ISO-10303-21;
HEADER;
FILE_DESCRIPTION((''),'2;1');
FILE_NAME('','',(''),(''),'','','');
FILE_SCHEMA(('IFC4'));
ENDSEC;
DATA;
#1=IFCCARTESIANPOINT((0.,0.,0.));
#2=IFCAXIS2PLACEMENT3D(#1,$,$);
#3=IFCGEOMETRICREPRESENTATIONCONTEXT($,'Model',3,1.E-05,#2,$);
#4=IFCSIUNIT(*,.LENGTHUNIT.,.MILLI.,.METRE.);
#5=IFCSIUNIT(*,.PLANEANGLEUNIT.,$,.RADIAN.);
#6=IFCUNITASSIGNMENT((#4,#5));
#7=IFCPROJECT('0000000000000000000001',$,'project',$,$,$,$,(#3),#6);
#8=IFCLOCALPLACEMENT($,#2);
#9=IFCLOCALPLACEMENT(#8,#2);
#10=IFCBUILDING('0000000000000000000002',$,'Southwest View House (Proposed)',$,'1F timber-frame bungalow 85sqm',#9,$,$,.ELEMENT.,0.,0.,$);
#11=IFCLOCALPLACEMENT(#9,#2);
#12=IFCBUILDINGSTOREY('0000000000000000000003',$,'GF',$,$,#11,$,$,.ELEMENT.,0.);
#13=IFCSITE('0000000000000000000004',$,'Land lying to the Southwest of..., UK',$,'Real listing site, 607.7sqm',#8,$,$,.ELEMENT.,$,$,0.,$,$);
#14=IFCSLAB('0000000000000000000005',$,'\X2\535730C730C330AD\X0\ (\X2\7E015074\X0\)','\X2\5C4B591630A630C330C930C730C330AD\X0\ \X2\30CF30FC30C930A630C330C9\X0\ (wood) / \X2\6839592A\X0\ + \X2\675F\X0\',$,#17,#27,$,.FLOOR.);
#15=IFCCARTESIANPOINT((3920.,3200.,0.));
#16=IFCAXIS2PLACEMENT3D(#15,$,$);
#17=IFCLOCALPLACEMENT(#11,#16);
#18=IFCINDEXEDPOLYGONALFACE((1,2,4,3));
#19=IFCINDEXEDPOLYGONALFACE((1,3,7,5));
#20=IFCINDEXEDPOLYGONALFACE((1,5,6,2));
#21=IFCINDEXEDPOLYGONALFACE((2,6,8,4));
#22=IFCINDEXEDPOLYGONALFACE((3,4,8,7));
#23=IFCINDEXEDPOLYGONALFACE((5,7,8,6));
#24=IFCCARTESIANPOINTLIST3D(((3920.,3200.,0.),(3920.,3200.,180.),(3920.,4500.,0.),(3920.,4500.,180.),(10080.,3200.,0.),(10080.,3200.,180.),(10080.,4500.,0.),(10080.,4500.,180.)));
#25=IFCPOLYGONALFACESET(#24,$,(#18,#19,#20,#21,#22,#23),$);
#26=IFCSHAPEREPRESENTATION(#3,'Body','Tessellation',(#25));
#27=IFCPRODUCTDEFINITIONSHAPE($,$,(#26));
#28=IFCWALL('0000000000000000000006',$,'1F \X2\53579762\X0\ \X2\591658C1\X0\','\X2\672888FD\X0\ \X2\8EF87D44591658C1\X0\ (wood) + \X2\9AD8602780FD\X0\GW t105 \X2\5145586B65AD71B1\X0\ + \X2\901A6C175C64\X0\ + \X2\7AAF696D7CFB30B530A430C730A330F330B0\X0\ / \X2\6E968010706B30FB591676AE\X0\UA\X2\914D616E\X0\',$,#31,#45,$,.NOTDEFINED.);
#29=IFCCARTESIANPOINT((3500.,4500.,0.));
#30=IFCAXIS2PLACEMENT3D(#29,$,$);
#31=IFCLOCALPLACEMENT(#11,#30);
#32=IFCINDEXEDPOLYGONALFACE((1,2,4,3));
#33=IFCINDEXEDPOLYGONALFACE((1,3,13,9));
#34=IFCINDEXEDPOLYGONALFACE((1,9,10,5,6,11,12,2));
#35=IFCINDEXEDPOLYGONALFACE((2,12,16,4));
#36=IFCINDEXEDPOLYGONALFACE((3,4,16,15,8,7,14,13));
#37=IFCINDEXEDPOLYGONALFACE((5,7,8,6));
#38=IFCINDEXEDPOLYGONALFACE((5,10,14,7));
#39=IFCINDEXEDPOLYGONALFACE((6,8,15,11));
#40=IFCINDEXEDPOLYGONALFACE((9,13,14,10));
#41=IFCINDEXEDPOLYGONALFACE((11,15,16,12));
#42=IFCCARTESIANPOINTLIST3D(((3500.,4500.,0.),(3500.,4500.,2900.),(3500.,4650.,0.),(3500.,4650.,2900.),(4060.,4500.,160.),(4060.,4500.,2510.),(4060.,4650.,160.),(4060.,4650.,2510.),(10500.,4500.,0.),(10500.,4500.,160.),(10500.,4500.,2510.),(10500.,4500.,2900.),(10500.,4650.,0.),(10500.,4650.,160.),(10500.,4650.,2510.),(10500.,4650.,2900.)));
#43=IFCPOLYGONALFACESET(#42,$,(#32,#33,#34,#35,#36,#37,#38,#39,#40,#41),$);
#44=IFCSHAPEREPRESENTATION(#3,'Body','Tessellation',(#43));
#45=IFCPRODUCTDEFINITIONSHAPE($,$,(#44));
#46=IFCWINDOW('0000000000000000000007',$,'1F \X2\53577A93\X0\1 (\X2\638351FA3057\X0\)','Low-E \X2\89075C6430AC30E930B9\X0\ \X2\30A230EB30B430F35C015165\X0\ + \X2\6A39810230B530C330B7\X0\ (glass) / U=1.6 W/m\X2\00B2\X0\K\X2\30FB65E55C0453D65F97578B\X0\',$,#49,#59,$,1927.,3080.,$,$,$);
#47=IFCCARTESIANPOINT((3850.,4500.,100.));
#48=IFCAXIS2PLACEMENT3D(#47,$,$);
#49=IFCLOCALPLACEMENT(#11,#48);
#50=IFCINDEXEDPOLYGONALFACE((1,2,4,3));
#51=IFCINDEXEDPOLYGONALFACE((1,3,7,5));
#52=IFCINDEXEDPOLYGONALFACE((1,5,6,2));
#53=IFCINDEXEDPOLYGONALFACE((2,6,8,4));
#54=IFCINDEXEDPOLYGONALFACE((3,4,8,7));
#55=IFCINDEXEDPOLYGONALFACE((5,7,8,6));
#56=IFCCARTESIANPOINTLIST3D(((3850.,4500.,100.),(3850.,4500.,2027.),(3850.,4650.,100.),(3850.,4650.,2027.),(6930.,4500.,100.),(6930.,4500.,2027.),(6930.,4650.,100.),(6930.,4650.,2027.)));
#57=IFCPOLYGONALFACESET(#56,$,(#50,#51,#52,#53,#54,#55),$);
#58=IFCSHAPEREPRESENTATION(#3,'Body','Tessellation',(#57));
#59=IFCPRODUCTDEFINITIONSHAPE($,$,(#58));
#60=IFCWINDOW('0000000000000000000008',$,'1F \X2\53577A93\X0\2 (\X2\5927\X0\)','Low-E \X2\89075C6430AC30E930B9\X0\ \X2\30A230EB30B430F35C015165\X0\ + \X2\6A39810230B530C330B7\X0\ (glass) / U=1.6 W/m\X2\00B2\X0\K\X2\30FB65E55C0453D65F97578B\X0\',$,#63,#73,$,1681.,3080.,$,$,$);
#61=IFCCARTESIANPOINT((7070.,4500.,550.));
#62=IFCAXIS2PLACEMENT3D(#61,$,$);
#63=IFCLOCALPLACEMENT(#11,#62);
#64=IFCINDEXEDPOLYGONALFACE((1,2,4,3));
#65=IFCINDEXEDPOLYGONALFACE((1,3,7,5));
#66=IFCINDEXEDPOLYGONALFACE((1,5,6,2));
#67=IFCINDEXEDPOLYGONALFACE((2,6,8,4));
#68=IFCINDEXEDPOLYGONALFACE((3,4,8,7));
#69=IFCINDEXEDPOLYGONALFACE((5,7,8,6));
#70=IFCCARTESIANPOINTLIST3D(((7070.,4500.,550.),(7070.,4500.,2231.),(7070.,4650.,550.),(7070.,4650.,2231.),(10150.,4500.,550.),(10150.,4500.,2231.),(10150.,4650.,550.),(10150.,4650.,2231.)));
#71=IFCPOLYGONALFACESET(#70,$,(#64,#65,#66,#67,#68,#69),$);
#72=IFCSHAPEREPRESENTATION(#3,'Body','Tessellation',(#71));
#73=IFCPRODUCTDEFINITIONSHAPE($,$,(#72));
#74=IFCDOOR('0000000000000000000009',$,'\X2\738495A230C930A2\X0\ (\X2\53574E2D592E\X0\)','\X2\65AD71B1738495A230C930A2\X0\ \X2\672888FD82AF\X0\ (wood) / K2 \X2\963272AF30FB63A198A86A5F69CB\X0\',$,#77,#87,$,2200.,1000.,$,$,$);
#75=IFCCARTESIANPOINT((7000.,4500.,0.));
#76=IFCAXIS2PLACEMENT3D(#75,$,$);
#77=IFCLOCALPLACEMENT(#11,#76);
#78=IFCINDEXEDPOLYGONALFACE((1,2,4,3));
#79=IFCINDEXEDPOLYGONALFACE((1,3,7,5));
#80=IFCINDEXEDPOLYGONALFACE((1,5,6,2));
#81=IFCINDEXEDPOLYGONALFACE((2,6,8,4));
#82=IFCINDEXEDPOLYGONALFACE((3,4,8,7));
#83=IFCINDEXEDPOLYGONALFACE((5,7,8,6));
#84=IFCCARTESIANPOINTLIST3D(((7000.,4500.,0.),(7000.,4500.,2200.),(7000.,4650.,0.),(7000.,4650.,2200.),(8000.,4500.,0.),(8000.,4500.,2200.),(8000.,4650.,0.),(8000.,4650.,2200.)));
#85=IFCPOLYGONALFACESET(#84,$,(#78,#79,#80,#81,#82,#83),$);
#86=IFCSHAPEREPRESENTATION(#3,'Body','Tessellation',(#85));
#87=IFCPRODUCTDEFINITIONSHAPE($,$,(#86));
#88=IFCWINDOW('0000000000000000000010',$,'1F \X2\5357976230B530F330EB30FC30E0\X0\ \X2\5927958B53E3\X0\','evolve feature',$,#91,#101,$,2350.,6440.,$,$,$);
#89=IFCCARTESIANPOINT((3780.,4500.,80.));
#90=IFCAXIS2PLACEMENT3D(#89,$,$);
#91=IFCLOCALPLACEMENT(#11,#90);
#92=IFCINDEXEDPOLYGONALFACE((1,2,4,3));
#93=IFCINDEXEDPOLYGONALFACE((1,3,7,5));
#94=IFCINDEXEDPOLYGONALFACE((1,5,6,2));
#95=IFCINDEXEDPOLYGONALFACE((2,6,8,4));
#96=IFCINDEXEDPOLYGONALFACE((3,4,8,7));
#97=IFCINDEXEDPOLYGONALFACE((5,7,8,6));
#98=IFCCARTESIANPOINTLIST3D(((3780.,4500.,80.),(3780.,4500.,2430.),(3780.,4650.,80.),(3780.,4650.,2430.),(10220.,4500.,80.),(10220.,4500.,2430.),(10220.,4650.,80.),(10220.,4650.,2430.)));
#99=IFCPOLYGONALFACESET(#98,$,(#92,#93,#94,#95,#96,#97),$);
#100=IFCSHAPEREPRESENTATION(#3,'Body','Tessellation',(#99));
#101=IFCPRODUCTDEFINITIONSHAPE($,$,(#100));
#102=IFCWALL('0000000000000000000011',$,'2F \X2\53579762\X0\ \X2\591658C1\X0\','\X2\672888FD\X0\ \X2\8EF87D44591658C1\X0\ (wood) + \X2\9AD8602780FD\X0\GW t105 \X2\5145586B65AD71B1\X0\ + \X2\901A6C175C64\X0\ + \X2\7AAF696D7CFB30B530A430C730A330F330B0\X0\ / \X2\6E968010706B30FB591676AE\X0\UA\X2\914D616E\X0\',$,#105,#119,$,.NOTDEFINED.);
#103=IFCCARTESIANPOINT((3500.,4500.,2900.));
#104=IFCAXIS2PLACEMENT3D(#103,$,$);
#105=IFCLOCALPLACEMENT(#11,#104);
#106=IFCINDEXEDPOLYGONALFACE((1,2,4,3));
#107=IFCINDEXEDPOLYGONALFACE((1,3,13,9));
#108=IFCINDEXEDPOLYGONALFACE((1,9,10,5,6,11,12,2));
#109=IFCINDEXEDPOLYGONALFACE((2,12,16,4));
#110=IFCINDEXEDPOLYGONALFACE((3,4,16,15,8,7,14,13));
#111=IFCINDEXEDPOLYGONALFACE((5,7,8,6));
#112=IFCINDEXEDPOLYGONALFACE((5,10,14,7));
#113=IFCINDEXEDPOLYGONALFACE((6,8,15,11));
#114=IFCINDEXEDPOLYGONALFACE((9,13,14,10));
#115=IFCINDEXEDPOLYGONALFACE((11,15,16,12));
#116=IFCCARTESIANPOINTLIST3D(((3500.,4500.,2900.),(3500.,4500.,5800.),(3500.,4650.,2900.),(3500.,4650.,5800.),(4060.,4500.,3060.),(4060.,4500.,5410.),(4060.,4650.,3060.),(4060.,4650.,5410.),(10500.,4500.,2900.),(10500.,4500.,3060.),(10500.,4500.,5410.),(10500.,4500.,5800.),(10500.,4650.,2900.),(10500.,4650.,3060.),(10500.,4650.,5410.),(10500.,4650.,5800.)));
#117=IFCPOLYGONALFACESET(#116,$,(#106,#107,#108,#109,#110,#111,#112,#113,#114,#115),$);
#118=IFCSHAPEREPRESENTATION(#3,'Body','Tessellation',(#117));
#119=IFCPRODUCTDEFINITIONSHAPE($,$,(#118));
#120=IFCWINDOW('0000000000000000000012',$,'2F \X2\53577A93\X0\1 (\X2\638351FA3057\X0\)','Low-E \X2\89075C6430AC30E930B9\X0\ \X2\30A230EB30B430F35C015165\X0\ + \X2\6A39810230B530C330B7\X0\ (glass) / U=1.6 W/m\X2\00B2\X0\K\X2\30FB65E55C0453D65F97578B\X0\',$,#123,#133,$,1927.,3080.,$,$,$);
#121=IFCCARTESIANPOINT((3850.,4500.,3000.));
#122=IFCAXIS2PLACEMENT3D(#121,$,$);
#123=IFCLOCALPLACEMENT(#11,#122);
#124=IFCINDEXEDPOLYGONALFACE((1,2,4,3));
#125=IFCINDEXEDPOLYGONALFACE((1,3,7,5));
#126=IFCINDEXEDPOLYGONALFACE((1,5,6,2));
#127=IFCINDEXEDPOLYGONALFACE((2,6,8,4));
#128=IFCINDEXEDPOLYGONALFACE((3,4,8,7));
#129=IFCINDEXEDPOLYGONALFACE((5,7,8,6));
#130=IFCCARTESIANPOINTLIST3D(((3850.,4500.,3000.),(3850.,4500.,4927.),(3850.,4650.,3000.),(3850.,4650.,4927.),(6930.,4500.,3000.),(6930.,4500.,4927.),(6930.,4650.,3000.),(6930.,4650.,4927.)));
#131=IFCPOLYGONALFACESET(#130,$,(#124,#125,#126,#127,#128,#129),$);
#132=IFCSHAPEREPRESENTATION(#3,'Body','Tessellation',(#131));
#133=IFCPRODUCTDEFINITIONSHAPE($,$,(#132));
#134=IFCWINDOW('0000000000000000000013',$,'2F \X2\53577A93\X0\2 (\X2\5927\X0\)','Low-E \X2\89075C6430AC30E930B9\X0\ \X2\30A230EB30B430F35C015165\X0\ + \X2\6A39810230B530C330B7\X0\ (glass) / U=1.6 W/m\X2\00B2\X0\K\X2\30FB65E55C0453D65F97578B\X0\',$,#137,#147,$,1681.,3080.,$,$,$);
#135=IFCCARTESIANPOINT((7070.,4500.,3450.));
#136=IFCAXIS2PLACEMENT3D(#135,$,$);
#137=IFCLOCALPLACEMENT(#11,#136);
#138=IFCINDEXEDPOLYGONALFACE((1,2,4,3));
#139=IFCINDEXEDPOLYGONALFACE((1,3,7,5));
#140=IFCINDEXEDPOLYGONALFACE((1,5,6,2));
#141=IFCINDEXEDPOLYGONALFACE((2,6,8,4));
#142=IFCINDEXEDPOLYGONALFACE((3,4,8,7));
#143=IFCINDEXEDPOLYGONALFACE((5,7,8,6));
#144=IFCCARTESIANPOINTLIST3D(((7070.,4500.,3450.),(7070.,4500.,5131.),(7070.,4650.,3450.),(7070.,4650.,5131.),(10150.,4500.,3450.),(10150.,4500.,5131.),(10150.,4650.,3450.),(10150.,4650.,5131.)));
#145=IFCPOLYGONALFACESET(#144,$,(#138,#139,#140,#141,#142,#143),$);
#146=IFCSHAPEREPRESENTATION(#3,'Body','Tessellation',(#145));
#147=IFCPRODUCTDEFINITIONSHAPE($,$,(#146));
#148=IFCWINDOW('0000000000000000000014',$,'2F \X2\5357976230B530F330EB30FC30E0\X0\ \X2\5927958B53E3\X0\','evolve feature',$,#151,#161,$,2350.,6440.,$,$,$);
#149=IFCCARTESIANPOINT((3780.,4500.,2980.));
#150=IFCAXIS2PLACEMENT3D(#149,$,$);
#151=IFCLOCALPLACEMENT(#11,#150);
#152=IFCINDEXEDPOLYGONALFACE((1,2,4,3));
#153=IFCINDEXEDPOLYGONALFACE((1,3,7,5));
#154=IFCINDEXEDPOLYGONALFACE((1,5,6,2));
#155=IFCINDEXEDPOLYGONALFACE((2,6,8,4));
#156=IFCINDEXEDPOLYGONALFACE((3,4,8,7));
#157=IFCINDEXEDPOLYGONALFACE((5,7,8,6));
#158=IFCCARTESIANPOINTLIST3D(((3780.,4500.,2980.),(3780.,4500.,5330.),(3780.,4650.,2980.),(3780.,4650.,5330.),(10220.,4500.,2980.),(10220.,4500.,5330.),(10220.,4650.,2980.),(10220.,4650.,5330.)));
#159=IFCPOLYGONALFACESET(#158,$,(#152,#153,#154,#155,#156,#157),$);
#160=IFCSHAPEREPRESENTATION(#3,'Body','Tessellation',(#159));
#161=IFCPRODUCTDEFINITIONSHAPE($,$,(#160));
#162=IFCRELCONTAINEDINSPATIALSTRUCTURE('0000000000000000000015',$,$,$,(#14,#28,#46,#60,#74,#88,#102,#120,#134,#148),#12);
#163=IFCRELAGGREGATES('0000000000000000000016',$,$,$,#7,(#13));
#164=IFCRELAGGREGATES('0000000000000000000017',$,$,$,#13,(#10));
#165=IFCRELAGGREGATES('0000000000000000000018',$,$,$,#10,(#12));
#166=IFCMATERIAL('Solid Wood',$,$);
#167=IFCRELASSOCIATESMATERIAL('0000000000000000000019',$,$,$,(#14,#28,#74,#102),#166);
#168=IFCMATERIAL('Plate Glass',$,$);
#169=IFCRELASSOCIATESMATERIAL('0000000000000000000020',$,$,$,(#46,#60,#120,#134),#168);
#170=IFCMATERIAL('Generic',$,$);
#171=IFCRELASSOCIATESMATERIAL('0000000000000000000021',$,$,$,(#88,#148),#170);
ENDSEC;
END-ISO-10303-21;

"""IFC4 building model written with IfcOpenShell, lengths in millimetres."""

from ifc_helpers import new_model, si_unit, frame, frame_2d, origin, place, context, project, spatial, rectangle, extrude, material, element, fill, save


model = new_model("IFC4")

# Units and contexts
model_context = context("Model", 3, precision=1e-05, world=origin())
ifc_project = project(units=[si_unit("LENGTHUNIT", "METRE", prefix="MILLI"), si_unit("PLANEANGLEUNIT", "RADIAN")], contexts=[model_context])

# Site, building, storey
site_placement = place(None, origin())
site = spatial("IfcSite", under=ifc_project, at=site_placement, Name="Land lying to the Southwest of..., UK", ObjectType="Real listing site, 607.7sqm", CompositionType="ELEMENT", RefElevation=0.0)
building_placement = place(site_placement, origin())
building = spatial("IfcBuilding", under=site, at=building_placement, Name="Southwest View House (Proposed)", ObjectType="1F timber-frame bungalow 85sqm", CompositionType="ELEMENT", ElevationOfRefHeight=0.0, ElevationOfTerrain=0.0)
storey_placement = place(building_placement, origin())
storey = spatial("IfcBuildingStorey", under=building, at=storey_placement, Name="GF", CompositionType="ELEMENT", Elevation=0.0)

# Slab
ifc_material_1 = material(Name="Solid Wood")
slab_1_placement = place(storey_placement, frame((3920.0, 3200.0, 0.0)))
element("IfcSlab", 1, at=slab_1_placement, inside=storey, material=ifc_material_1, Name="南デッキ (縁側)", Description="屋外ウッドデッキ ハードウッド (wood) / 根太 + 束", PredefinedType="FLOOR", context=model_context, shape_type="SweptSolid", body=[
    extrude(rectangle(XDim=6160.0, YDim=1300.0, at=frame_2d((3080.0, 650.0))), frame((3920.0, 3200.0, 0.0)), (0.0, 0.0, 1.0), 180.0),
])
ifc_material_2 = material(Name="Generic")

# Wall, openings, windows, door
wall_1_placement = place(storey_placement, frame((3500.0, 4500.0, 0.0)))
wall_1 = element("IfcWall", 2, at=wall_1_placement, inside=storey, material=ifc_material_1, Name="1F 南面 外壁", Description="木製 軸組外壁 (wood) + 高性能GW t105 充填断熱 + 通気層 + 窯業系サイディング / 準耐火・外皮UA配慮", PredefinedType="NOTDEFINED", context=model_context, shape_type="SweptSolid", body=[
    extrude(rectangle(XDim=7000.0, YDim=150.0, at=frame_2d((3500.0, 75.0))), frame((3500.0, 4500.0, 0.0)), (0.0, 0.0, 1.0), 2900.0),
])
opening_1_placement = place(storey_placement, frame((3850.0, 4500.0, 100.0)))
opening_1 = element("IfcOpeningElement", 3, at=opening_1_placement, cuts=wall_1, PredefinedType="NOTDEFINED", context=model_context, shape_type="SweptSolid", body=[
    extrude(rectangle(XDim=3080.0, YDim=150.0, at=frame_2d((1540.0, 75.0))), frame((3850.0, 4500.0, 100.0)), (0.0, 0.0, 1.0), 1927.0),
])
opening_2_placement = place(storey_placement, frame((7070.0, 4500.0, 550.0)))
opening_2 = element("IfcOpeningElement", 4, at=opening_2_placement, cuts=wall_1, PredefinedType="NOTDEFINED", context=model_context, shape_type="SweptSolid", body=[
    extrude(rectangle(XDim=3080.0, YDim=150.0, at=frame_2d((1540.0, 75.0))), frame((7070.0, 4500.0, 550.0)), (0.0, 0.0, 1.0), 1681.0),
])
opening_3_placement = place(storey_placement, frame((7000.0, 4500.0, 0.0)))
opening_3 = element("IfcOpeningElement", 5, at=opening_3_placement, cuts=wall_1, PredefinedType="NOTDEFINED", context=model_context, shape_type="SweptSolid", body=[
    extrude(rectangle(XDim=1000.0, YDim=150.0, at=frame_2d((500.0, 75.0))), frame((7000.0, 4500.0, 0.0)), (0.0, 0.0, 1.0), 2200.0),
])
opening_4_placement = place(storey_placement, frame((3780.0, 4500.0, 80.0)))
opening_4 = element("IfcOpeningElement", 6, at=opening_4_placement, cuts=wall_1, PredefinedType="NOTDEFINED", context=model_context, shape_type="SweptSolid", body=[
    extrude(rectangle(XDim=6440.0, YDim=150.0, at=frame_2d((3220.0, 75.0))), frame((3780.0, 4500.0, 80.0)), (0.0, 0.0, 1.0), 2350.0),
])
ifc_material_3 = material(Name="Plate Glass")
window_1_placement = place(storey_placement, frame((3850.0, 4500.0, 100.0)))
window_1 = element("IfcWindow", 7, at=window_1_placement, inside=storey, material=ifc_material_3, Name="1F 南窓1 (掃出し)", Description="Low-E 複層ガラス アルゴン封入 + 樹脂サッシ (glass) / U=1.6 W/m²K・日射取得型", OverallHeight=1927.0, OverallWidth=3080.0, context=model_context, shape_type="SweptSolid", body=[
    extrude(rectangle(XDim=3080.0, YDim=150.0, at=frame_2d((1540.0, 75.0))), frame((3850.0, 4500.0, 100.0)), (0.0, 0.0, 1.0), 1927.0),
])
fill(opening_1, window_1)
window_2_placement = place(storey_placement, frame((7070.0, 4500.0, 550.0)))
window_2 = element("IfcWindow", 8, at=window_2_placement, inside=storey, material=ifc_material_3, Name="1F 南窓2 (大)", Description="Low-E 複層ガラス アルゴン封入 + 樹脂サッシ (glass) / U=1.6 W/m²K・日射取得型", OverallHeight=1681.0, OverallWidth=3080.0, context=model_context, shape_type="SweptSolid", body=[
    extrude(rectangle(XDim=3080.0, YDim=150.0, at=frame_2d((1540.0, 75.0))), frame((7070.0, 4500.0, 550.0)), (0.0, 0.0, 1.0), 1681.0),
])
fill(opening_2, window_2)
door_placement = place(storey_placement, frame((7000.0, 4500.0, 0.0)))
door = element("IfcDoor", 9, at=door_placement, inside=storey, material=ifc_material_1, Name="玄関ドア (南中央)", Description="断熱玄関ドア 木製芯 (wood) / K2 防犯・採風機構", OverallHeight=2200.0, OverallWidth=1000.0, context=model_context, shape_type="SweptSolid", body=[
    extrude(rectangle(XDim=1000.0, YDim=150.0, at=frame_2d((500.0, 75.0))), frame((7000.0, 4500.0, 0.0)), (0.0, 0.0, 1.0), 2200.0),
])
fill(opening_3, door)
window_3_placement = place(storey_placement, frame((3780.0, 4500.0, 80.0)))
window_3 = element("IfcWindow", 10, at=window_3_placement, inside=storey, material=ifc_material_2, Name="1F 南面サンルーム 大開口", Description="evolve feature", OverallHeight=2350.0, OverallWidth=6440.0, context=model_context, shape_type="SweptSolid", body=[
    extrude(rectangle(XDim=6440.0, YDim=150.0, at=frame_2d((3220.0, 75.0))), frame((3780.0, 4500.0, 80.0)), (0.0, 0.0, 1.0), 2350.0),
])
fill(opening_4, window_3)

# Wall, openings, windows
wall_2_placement = place(storey_placement, frame((3500.0, 4500.0, 2900.0)))
wall_2 = element("IfcWall", 11, at=wall_2_placement, inside=storey, material=ifc_material_1, Name="2F 南面 外壁", Description="木製 軸組外壁 (wood) + 高性能GW t105 充填断熱 + 通気層 + 窯業系サイディング / 準耐火・外皮UA配慮", PredefinedType="NOTDEFINED", context=model_context, shape_type="SweptSolid", body=[
    extrude(rectangle(XDim=7000.0, YDim=150.0, at=frame_2d((3500.0, 75.0))), frame((3500.0, 4500.0, 2900.0)), (0.0, 0.0, 1.0), 2900.0),
])
opening_5_placement = place(storey_placement, frame((3850.0, 4500.0, 3000.0)))
opening_5 = element("IfcOpeningElement", 12, at=opening_5_placement, cuts=wall_2, PredefinedType="NOTDEFINED", context=model_context, shape_type="SweptSolid", body=[
    extrude(rectangle(XDim=3080.0, YDim=150.0, at=frame_2d((1540.0, 75.0))), frame((3850.0, 4500.0, 3000.0)), (0.0, 0.0, 1.0), 1927.0),
])
opening_6_placement = place(storey_placement, frame((7070.0, 4500.0, 3450.0)))
opening_6 = element("IfcOpeningElement", 13, at=opening_6_placement, cuts=wall_2, PredefinedType="NOTDEFINED", context=model_context, shape_type="SweptSolid", body=[
    extrude(rectangle(XDim=3080.0, YDim=150.0, at=frame_2d((1540.0, 75.0))), frame((7070.0, 4500.0, 3450.0)), (0.0, 0.0, 1.0), 1681.0),
])
opening_7_placement = place(storey_placement, frame((3780.0, 4500.0, 2980.0)))
opening_7 = element("IfcOpeningElement", 14, at=opening_7_placement, cuts=wall_2, PredefinedType="NOTDEFINED", context=model_context, shape_type="SweptSolid", body=[
    extrude(rectangle(XDim=6440.0, YDim=150.0, at=frame_2d((3220.0, 75.0))), frame((3780.0, 4500.0, 2980.0)), (0.0, 0.0, 1.0), 2350.0),
])
window_4_placement = place(storey_placement, frame((3850.0, 4500.0, 3000.0)))
window_4 = element("IfcWindow", 15, at=window_4_placement, inside=storey, material=ifc_material_3, Name="2F 南窓1 (掃出し)", Description="Low-E 複層ガラス アルゴン封入 + 樹脂サッシ (glass) / U=1.6 W/m²K・日射取得型", OverallHeight=1927.0, OverallWidth=3080.0, context=model_context, shape_type="SweptSolid", body=[
    extrude(rectangle(XDim=3080.0, YDim=150.0, at=frame_2d((1540.0, 75.0))), frame((3850.0, 4500.0, 3000.0)), (0.0, 0.0, 1.0), 1927.0),
])
fill(opening_5, window_4)
window_5_placement = place(storey_placement, frame((7070.0, 4500.0, 3450.0)))
window_5 = element("IfcWindow", 16, at=window_5_placement, inside=storey, material=ifc_material_3, Name="2F 南窓2 (大)", Description="Low-E 複層ガラス アルゴン封入 + 樹脂サッシ (glass) / U=1.6 W/m²K・日射取得型", OverallHeight=1681.0, OverallWidth=3080.0, context=model_context, shape_type="SweptSolid", body=[
    extrude(rectangle(XDim=3080.0, YDim=150.0, at=frame_2d((1540.0, 75.0))), frame((7070.0, 4500.0, 3450.0)), (0.0, 0.0, 1.0), 1681.0),
])
fill(opening_6, window_5)
window_6_placement = place(storey_placement, frame((3780.0, 4500.0, 2980.0)))
window_6 = element("IfcWindow", 17, at=window_6_placement, inside=storey, material=ifc_material_2, Name="2F 南面サンルーム 大開口", Description="evolve feature", OverallHeight=2350.0, OverallWidth=6440.0, context=model_context, shape_type="SweptSolid", body=[
    extrude(rectangle(XDim=6440.0, YDim=150.0, at=frame_2d((3220.0, 75.0))), frame((3780.0, 4500.0, 2980.0)), (0.0, 0.0, 1.0), 2350.0),
])
fill(opening_7, window_6)

save(model, "model.ifc")
